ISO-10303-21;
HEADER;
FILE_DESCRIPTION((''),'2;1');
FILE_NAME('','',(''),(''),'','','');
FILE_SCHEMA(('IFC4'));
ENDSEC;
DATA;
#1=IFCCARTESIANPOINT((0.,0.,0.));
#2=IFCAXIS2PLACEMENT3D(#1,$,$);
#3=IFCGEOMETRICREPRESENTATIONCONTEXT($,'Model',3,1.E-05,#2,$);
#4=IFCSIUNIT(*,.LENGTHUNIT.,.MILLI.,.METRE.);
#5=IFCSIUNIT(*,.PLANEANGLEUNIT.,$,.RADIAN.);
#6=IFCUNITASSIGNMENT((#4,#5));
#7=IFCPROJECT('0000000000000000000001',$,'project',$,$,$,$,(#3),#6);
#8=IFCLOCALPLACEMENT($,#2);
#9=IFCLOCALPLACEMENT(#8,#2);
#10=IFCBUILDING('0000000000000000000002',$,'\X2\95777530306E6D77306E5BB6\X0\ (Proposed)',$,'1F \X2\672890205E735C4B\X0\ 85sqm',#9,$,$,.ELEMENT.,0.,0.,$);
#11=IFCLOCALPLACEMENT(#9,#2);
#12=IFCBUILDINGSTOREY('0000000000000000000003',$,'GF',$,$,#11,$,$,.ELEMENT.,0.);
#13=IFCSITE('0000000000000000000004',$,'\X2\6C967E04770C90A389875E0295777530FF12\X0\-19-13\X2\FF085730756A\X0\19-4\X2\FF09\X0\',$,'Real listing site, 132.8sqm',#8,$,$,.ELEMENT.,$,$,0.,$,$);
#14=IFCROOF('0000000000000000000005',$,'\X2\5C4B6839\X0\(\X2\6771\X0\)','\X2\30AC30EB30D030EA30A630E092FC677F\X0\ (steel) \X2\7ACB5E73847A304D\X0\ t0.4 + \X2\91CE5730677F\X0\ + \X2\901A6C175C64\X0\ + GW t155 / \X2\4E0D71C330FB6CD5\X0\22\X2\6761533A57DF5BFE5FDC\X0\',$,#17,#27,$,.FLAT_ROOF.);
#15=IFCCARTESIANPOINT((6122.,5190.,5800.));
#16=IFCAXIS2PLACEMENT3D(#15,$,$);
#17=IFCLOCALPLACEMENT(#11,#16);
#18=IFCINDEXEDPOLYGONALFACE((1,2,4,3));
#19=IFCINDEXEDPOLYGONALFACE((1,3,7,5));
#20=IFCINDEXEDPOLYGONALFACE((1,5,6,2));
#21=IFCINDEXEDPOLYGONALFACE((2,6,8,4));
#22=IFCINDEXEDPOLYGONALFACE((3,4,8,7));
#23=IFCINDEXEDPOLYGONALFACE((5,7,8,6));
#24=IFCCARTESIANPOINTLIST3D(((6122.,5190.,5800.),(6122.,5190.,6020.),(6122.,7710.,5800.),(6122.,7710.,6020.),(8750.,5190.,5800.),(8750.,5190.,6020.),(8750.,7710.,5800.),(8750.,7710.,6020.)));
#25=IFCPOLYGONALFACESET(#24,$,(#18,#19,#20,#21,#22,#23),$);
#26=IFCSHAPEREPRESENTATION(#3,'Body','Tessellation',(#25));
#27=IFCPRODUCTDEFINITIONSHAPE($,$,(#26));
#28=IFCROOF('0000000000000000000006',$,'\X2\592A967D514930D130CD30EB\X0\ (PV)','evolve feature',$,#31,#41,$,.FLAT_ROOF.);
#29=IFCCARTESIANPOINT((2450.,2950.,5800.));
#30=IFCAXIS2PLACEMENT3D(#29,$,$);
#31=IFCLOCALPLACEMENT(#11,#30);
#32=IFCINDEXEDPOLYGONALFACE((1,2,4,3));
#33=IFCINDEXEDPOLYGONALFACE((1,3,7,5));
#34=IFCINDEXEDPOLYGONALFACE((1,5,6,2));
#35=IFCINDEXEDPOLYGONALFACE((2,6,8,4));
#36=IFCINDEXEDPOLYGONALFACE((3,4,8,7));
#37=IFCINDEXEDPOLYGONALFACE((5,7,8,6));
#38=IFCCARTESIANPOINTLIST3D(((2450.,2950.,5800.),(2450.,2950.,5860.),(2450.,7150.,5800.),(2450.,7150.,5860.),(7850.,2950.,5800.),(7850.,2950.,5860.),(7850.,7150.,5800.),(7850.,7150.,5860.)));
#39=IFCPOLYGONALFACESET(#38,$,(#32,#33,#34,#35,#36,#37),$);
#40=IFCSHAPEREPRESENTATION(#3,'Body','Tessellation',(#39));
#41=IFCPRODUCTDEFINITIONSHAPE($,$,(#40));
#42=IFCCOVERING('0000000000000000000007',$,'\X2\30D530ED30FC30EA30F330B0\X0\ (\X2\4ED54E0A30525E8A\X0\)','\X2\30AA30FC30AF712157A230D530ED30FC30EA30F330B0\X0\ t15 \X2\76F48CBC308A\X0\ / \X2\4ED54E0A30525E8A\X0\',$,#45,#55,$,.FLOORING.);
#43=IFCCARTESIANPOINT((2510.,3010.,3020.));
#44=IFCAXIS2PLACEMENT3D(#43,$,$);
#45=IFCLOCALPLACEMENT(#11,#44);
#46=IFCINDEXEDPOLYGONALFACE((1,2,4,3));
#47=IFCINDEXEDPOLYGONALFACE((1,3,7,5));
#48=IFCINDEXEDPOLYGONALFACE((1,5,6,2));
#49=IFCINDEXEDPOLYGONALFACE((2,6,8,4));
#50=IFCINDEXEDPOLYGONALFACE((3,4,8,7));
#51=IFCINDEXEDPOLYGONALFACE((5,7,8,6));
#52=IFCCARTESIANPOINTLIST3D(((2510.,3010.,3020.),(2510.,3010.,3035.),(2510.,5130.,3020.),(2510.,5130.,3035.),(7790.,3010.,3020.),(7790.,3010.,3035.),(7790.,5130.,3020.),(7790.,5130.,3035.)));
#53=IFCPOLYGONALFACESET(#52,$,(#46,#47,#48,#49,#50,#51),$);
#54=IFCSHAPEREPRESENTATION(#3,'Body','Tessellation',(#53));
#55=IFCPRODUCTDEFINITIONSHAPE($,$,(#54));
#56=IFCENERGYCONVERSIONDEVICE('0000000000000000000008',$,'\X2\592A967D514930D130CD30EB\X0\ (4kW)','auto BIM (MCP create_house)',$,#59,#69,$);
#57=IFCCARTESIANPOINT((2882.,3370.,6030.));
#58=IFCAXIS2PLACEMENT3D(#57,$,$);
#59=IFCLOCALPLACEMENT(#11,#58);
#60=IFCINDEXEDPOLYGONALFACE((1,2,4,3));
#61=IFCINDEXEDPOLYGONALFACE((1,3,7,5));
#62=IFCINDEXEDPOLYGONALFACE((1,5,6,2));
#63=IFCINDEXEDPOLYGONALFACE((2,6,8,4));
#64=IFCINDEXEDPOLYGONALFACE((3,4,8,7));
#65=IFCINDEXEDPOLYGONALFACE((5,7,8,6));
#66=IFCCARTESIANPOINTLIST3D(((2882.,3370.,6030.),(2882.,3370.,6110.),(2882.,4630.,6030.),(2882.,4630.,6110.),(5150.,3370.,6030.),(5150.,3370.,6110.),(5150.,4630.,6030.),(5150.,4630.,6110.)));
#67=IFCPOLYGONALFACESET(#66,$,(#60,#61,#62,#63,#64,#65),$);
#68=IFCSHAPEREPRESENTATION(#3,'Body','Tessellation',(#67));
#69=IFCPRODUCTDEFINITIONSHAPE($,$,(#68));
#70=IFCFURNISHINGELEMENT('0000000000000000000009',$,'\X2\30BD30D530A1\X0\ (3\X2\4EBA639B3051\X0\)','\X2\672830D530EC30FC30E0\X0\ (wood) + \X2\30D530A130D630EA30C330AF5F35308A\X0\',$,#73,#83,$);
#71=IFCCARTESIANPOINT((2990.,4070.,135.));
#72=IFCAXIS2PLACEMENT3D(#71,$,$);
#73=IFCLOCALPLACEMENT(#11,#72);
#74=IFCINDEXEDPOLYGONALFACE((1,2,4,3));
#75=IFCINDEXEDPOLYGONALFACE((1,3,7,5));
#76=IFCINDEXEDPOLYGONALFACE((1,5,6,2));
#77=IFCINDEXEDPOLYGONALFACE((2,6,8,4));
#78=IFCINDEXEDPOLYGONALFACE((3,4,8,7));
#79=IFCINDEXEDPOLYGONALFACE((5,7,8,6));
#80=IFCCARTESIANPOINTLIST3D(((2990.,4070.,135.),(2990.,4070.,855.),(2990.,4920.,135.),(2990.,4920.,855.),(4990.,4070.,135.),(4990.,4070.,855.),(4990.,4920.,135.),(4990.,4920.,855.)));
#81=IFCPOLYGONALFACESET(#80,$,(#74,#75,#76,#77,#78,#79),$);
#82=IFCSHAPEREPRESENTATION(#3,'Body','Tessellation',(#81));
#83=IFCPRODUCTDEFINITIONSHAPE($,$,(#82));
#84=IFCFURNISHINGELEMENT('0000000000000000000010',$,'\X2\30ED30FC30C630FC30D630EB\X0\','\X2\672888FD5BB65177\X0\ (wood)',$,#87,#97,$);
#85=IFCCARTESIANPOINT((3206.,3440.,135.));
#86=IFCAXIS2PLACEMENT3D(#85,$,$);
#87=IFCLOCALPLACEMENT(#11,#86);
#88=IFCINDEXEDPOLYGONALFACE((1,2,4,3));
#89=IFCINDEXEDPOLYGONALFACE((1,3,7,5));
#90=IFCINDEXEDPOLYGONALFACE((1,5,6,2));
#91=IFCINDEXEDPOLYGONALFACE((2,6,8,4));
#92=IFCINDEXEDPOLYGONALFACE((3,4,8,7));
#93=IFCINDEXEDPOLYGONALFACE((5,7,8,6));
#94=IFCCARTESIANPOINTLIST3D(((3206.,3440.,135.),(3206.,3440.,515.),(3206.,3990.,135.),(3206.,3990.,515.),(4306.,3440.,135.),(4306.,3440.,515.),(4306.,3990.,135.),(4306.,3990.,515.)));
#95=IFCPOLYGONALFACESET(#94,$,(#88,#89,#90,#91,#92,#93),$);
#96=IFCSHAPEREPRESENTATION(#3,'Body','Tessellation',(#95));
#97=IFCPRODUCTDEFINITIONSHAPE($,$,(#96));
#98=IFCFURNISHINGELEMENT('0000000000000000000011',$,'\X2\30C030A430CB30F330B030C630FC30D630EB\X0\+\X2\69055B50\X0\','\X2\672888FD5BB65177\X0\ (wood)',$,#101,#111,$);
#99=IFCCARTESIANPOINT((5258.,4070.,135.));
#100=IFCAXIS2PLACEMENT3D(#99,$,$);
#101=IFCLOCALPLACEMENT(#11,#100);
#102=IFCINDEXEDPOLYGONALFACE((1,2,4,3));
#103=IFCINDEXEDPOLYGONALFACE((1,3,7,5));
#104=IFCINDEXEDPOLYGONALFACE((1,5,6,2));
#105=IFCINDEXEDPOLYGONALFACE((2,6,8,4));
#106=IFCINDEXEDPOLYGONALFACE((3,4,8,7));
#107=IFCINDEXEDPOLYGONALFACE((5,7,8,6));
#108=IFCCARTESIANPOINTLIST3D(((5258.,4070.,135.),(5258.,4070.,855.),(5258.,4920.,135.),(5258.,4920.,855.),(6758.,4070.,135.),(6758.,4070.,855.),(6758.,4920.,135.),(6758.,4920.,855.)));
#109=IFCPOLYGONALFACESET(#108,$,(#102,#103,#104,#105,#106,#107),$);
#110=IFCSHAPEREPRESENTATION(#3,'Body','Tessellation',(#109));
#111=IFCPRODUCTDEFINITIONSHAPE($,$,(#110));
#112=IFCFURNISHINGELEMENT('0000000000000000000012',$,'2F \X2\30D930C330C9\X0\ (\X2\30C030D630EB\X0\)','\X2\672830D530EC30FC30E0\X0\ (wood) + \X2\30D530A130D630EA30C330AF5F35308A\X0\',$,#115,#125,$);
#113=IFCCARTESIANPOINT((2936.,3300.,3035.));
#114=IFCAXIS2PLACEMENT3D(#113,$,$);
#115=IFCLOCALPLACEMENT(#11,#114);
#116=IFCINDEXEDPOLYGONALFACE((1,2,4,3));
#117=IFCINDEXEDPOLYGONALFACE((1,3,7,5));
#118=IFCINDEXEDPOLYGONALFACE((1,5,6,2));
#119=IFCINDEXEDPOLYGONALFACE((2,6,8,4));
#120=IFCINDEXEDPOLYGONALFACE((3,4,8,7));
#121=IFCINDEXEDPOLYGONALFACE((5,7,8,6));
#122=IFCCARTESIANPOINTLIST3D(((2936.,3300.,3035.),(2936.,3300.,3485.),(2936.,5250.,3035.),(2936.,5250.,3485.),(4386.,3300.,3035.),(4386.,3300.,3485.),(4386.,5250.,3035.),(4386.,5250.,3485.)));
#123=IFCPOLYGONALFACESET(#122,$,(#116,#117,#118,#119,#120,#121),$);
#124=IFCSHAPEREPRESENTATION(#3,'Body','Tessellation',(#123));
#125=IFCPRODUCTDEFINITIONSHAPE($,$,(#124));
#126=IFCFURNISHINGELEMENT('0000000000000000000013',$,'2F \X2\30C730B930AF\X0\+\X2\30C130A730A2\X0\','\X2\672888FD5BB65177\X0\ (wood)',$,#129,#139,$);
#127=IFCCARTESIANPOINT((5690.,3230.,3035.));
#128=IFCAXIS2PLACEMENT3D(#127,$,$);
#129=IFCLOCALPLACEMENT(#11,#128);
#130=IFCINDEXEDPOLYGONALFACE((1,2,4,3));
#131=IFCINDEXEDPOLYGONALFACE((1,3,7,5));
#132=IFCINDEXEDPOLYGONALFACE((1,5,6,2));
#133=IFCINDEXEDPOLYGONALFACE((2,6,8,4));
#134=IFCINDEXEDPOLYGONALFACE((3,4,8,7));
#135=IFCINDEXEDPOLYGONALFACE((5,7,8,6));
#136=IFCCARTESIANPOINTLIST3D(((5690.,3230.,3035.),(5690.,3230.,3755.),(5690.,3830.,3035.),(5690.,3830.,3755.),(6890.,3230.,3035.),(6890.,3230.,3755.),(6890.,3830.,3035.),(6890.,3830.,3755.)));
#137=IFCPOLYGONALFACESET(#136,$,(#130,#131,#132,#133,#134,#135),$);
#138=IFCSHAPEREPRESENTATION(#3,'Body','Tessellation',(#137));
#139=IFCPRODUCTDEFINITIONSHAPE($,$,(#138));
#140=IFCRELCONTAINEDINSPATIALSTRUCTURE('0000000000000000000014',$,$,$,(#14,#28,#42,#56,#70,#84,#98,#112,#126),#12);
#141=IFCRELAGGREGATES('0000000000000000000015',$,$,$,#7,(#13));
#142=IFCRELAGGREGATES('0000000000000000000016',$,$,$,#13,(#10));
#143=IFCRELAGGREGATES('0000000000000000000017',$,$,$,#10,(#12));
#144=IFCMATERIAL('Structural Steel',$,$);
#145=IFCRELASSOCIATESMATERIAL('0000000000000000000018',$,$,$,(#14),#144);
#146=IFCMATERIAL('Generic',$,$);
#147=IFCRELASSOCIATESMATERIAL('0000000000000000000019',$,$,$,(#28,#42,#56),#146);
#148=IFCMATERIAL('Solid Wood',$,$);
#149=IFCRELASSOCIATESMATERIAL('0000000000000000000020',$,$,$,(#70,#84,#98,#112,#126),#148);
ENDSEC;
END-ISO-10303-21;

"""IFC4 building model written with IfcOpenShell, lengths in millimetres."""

from ifc_helpers import new_model, si_unit, frame, frame_2d, origin, place, context, project, spatial, rectangle, extrude, material, element, save


model = new_model("IFC4")

# Units and contexts
model_context = context("Model", 3, precision=1e-05, world=origin())
ifc_project = project(units=[si_unit("LENGTHUNIT", "METRE", prefix="MILLI"), si_unit("PLANEANGLEUNIT", "RADIAN")], contexts=[model_context])

# Site, building, storey
site_placement = place(None, origin())
site = spatial("IfcSite", under=ifc_project, at=site_placement, Name="沖縄県那覇市長田２-19-13（地番19-4）", ObjectType="Real listing site, 132.8sqm", CompositionType="ELEMENT", RefElevation=0.0)
building_placement = place(site_placement, origin())
building = spatial("IfcBuilding", under=site, at=building_placement, Name="長田の海の家 (Proposed)", ObjectType="1F 木造平屋 85sqm", CompositionType="ELEMENT", ElevationOfRefHeight=0.0, ElevationOfTerrain=0.0)
storey_placement = place(building_placement, origin())
storey = spatial("IfcBuildingStorey", under=building, at=storey_placement, Name="GF", CompositionType="ELEMENT", Elevation=0.0)

# Shared definitions
ifc_material_1 = material(Name="Solid Wood")

# Shared definitions
ifc_material_2 = material(Name="Generic")

# Roofs
ifc_material_3 = material(Name="Structural Steel")
roof_1_placement = place(storey_placement, frame((6122.0, 5190.0, 5800.0)))
element("IfcRoof", 1, at=roof_1_placement, inside=storey, material=ifc_material_3, Name="屋根(東)", Description="ガルバリウム鋼板 (steel) 立平葺き t0.4 + 野地板 + 通気層 + GW t155 / 不燃・法22条区域対応", PredefinedType="FLAT_ROOF", context=model_context, shape_type="SweptSolid", body=[
    extrude(rectangle(XDim=2628.0, YDim=2520.0, at=frame_2d((1314.0, 1260.0))), frame((6122.0, 5190.0, 5800.0)), (0.0, 0.0, 1.0), 220.0),
])
roof_2_placement = place(storey_placement, frame((2450.0, 2950.0, 5800.0)))
element("IfcRoof", 2, at=roof_2_placement, inside=storey, material=ifc_material_2, Name="太陽光パネル (PV)", Description="evolve feature", PredefinedType="FLAT_ROOF", context=model_context, shape_type="SweptSolid", body=[
    extrude(rectangle(XDim=5400.0, YDim=4200.0, at=frame_2d((2700.0, 2100.0))), frame((2450.0, 2950.0, 5800.0)), (0.0, 0.0, 1.0), 60.0),
])

# Covering
covering_placement = place(storey_placement, frame((2510.0, 3010.0, 3020.0)))
element("IfcCovering", 3, at=covering_placement, inside=storey, material=ifc_material_2, Name="フローリング (仕上げ床)", Description="オーク無垢フローリング t15 直貼り / 仕上げ床", PredefinedType="FLOORING", context=model_context, shape_type="SweptSolid", body=[
    extrude(rectangle(XDim=5280.0, YDim=2120.0, at=frame_2d((2640.0, 1060.0))), frame((2510.0, 3010.0, 3020.0)), (0.0, 0.0, 1.0), 15.0),
])

# Energy conversion device
energy_conversion_device_placement = place(storey_placement, frame((2882.0, 3370.0, 6030.0)))
element("IfcEnergyConversionDevice", 4, at=energy_conversion_device_placement, inside=storey, material=ifc_material_2, Name="太陽光パネル (4kW)", Description="auto BIM (MCP create_house)", context=model_context, shape_type="SweptSolid", body=[
    extrude(rectangle(XDim=2268.0, YDim=1260.0, at=frame_2d((1134.0, 630.0))), frame((2882.0, 3370.0, 6030.0)), (0.0, 0.0, 1.0), 80.0),
])

# Furnishing elements
furnishing_1_placement = place(storey_placement, frame((2990.0, 4070.0, 135.0)))
element("IfcFurnishingElement", 5, at=furnishing_1_placement, inside=storey, material=ifc_material_1, Name="ソファ (3人掛け)", Description="木フレーム (wood) + ファブリック張り", context=model_context, shape_type="SweptSolid", body=[
    extrude(rectangle(XDim=2000.0, YDim=850.0, at=frame_2d((1000.0, 425.0))), frame((2990.0, 4070.0, 135.0)), (0.0, 0.0, 1.0), 720.0),
])
furnishing_2_placement = place(storey_placement, frame((3206.0, 3440.0, 135.0)))
element("IfcFurnishingElement", 6, at=furnishing_2_placement, inside=storey, material=ifc_material_1, Name="ローテーブル", Description="木製家具 (wood)", context=model_context, shape_type="SweptSolid", body=[
    extrude(rectangle(XDim=1100.0, YDim=550.0, at=frame_2d((550.0, 275.0))), frame((3206.0, 3440.0, 135.0)), (0.0, 0.0, 1.0), 380.0),
])
furnishing_3_placement = place(storey_placement, frame((5258.0, 4070.0, 135.0)))
element("IfcFurnishingElement", 7, at=furnishing_3_placement, inside=storey, material=ifc_material_1, Name="ダイニングテーブル+椅子", Description="木製家具 (wood)", context=model_context, shape_type="SweptSolid", body=[
    extrude(rectangle(XDim=1500.0, YDim=850.0, at=frame_2d((750.0, 425.0))), frame((5258.0, 4070.0, 135.0)), (0.0, 0.0, 1.0), 720.0),
])
furnishing_4_placement = place(storey_placement, frame((2936.0, 3300.0, 3035.0)))
element("IfcFurnishingElement", 8, at=furnishing_4_placement, inside=storey, material=ifc_material_1, Name="2F ベッド (ダブル)", Description="木フレーム (wood) + ファブリック張り", context=model_context, shape_type="SweptSolid", body=[
    extrude(rectangle(XDim=1450.0, YDim=1950.0, at=frame_2d((725.0, 975.0))), frame((2936.0, 3300.0, 3035.0)), (0.0, 0.0, 1.0), 450.0),
])
furnishing_5_placement = place(storey_placement, frame((5690.0, 3230.0, 3035.0)))
element("IfcFurnishingElement", 9, at=furnishing_5_placement, inside=storey, material=ifc_material_1, Name="2F デスク+チェア", Description="木製家具 (wood)", context=model_context, shape_type="SweptSolid", body=[
    extrude(rectangle(XDim=1200.0, YDim=600.0, at=frame_2d((600.0, 300.0))), frame((5690.0, 3230.0, 3035.0)), (0.0, 0.0, 1.0), 720.0),
])

save(model, "model.ifc")
